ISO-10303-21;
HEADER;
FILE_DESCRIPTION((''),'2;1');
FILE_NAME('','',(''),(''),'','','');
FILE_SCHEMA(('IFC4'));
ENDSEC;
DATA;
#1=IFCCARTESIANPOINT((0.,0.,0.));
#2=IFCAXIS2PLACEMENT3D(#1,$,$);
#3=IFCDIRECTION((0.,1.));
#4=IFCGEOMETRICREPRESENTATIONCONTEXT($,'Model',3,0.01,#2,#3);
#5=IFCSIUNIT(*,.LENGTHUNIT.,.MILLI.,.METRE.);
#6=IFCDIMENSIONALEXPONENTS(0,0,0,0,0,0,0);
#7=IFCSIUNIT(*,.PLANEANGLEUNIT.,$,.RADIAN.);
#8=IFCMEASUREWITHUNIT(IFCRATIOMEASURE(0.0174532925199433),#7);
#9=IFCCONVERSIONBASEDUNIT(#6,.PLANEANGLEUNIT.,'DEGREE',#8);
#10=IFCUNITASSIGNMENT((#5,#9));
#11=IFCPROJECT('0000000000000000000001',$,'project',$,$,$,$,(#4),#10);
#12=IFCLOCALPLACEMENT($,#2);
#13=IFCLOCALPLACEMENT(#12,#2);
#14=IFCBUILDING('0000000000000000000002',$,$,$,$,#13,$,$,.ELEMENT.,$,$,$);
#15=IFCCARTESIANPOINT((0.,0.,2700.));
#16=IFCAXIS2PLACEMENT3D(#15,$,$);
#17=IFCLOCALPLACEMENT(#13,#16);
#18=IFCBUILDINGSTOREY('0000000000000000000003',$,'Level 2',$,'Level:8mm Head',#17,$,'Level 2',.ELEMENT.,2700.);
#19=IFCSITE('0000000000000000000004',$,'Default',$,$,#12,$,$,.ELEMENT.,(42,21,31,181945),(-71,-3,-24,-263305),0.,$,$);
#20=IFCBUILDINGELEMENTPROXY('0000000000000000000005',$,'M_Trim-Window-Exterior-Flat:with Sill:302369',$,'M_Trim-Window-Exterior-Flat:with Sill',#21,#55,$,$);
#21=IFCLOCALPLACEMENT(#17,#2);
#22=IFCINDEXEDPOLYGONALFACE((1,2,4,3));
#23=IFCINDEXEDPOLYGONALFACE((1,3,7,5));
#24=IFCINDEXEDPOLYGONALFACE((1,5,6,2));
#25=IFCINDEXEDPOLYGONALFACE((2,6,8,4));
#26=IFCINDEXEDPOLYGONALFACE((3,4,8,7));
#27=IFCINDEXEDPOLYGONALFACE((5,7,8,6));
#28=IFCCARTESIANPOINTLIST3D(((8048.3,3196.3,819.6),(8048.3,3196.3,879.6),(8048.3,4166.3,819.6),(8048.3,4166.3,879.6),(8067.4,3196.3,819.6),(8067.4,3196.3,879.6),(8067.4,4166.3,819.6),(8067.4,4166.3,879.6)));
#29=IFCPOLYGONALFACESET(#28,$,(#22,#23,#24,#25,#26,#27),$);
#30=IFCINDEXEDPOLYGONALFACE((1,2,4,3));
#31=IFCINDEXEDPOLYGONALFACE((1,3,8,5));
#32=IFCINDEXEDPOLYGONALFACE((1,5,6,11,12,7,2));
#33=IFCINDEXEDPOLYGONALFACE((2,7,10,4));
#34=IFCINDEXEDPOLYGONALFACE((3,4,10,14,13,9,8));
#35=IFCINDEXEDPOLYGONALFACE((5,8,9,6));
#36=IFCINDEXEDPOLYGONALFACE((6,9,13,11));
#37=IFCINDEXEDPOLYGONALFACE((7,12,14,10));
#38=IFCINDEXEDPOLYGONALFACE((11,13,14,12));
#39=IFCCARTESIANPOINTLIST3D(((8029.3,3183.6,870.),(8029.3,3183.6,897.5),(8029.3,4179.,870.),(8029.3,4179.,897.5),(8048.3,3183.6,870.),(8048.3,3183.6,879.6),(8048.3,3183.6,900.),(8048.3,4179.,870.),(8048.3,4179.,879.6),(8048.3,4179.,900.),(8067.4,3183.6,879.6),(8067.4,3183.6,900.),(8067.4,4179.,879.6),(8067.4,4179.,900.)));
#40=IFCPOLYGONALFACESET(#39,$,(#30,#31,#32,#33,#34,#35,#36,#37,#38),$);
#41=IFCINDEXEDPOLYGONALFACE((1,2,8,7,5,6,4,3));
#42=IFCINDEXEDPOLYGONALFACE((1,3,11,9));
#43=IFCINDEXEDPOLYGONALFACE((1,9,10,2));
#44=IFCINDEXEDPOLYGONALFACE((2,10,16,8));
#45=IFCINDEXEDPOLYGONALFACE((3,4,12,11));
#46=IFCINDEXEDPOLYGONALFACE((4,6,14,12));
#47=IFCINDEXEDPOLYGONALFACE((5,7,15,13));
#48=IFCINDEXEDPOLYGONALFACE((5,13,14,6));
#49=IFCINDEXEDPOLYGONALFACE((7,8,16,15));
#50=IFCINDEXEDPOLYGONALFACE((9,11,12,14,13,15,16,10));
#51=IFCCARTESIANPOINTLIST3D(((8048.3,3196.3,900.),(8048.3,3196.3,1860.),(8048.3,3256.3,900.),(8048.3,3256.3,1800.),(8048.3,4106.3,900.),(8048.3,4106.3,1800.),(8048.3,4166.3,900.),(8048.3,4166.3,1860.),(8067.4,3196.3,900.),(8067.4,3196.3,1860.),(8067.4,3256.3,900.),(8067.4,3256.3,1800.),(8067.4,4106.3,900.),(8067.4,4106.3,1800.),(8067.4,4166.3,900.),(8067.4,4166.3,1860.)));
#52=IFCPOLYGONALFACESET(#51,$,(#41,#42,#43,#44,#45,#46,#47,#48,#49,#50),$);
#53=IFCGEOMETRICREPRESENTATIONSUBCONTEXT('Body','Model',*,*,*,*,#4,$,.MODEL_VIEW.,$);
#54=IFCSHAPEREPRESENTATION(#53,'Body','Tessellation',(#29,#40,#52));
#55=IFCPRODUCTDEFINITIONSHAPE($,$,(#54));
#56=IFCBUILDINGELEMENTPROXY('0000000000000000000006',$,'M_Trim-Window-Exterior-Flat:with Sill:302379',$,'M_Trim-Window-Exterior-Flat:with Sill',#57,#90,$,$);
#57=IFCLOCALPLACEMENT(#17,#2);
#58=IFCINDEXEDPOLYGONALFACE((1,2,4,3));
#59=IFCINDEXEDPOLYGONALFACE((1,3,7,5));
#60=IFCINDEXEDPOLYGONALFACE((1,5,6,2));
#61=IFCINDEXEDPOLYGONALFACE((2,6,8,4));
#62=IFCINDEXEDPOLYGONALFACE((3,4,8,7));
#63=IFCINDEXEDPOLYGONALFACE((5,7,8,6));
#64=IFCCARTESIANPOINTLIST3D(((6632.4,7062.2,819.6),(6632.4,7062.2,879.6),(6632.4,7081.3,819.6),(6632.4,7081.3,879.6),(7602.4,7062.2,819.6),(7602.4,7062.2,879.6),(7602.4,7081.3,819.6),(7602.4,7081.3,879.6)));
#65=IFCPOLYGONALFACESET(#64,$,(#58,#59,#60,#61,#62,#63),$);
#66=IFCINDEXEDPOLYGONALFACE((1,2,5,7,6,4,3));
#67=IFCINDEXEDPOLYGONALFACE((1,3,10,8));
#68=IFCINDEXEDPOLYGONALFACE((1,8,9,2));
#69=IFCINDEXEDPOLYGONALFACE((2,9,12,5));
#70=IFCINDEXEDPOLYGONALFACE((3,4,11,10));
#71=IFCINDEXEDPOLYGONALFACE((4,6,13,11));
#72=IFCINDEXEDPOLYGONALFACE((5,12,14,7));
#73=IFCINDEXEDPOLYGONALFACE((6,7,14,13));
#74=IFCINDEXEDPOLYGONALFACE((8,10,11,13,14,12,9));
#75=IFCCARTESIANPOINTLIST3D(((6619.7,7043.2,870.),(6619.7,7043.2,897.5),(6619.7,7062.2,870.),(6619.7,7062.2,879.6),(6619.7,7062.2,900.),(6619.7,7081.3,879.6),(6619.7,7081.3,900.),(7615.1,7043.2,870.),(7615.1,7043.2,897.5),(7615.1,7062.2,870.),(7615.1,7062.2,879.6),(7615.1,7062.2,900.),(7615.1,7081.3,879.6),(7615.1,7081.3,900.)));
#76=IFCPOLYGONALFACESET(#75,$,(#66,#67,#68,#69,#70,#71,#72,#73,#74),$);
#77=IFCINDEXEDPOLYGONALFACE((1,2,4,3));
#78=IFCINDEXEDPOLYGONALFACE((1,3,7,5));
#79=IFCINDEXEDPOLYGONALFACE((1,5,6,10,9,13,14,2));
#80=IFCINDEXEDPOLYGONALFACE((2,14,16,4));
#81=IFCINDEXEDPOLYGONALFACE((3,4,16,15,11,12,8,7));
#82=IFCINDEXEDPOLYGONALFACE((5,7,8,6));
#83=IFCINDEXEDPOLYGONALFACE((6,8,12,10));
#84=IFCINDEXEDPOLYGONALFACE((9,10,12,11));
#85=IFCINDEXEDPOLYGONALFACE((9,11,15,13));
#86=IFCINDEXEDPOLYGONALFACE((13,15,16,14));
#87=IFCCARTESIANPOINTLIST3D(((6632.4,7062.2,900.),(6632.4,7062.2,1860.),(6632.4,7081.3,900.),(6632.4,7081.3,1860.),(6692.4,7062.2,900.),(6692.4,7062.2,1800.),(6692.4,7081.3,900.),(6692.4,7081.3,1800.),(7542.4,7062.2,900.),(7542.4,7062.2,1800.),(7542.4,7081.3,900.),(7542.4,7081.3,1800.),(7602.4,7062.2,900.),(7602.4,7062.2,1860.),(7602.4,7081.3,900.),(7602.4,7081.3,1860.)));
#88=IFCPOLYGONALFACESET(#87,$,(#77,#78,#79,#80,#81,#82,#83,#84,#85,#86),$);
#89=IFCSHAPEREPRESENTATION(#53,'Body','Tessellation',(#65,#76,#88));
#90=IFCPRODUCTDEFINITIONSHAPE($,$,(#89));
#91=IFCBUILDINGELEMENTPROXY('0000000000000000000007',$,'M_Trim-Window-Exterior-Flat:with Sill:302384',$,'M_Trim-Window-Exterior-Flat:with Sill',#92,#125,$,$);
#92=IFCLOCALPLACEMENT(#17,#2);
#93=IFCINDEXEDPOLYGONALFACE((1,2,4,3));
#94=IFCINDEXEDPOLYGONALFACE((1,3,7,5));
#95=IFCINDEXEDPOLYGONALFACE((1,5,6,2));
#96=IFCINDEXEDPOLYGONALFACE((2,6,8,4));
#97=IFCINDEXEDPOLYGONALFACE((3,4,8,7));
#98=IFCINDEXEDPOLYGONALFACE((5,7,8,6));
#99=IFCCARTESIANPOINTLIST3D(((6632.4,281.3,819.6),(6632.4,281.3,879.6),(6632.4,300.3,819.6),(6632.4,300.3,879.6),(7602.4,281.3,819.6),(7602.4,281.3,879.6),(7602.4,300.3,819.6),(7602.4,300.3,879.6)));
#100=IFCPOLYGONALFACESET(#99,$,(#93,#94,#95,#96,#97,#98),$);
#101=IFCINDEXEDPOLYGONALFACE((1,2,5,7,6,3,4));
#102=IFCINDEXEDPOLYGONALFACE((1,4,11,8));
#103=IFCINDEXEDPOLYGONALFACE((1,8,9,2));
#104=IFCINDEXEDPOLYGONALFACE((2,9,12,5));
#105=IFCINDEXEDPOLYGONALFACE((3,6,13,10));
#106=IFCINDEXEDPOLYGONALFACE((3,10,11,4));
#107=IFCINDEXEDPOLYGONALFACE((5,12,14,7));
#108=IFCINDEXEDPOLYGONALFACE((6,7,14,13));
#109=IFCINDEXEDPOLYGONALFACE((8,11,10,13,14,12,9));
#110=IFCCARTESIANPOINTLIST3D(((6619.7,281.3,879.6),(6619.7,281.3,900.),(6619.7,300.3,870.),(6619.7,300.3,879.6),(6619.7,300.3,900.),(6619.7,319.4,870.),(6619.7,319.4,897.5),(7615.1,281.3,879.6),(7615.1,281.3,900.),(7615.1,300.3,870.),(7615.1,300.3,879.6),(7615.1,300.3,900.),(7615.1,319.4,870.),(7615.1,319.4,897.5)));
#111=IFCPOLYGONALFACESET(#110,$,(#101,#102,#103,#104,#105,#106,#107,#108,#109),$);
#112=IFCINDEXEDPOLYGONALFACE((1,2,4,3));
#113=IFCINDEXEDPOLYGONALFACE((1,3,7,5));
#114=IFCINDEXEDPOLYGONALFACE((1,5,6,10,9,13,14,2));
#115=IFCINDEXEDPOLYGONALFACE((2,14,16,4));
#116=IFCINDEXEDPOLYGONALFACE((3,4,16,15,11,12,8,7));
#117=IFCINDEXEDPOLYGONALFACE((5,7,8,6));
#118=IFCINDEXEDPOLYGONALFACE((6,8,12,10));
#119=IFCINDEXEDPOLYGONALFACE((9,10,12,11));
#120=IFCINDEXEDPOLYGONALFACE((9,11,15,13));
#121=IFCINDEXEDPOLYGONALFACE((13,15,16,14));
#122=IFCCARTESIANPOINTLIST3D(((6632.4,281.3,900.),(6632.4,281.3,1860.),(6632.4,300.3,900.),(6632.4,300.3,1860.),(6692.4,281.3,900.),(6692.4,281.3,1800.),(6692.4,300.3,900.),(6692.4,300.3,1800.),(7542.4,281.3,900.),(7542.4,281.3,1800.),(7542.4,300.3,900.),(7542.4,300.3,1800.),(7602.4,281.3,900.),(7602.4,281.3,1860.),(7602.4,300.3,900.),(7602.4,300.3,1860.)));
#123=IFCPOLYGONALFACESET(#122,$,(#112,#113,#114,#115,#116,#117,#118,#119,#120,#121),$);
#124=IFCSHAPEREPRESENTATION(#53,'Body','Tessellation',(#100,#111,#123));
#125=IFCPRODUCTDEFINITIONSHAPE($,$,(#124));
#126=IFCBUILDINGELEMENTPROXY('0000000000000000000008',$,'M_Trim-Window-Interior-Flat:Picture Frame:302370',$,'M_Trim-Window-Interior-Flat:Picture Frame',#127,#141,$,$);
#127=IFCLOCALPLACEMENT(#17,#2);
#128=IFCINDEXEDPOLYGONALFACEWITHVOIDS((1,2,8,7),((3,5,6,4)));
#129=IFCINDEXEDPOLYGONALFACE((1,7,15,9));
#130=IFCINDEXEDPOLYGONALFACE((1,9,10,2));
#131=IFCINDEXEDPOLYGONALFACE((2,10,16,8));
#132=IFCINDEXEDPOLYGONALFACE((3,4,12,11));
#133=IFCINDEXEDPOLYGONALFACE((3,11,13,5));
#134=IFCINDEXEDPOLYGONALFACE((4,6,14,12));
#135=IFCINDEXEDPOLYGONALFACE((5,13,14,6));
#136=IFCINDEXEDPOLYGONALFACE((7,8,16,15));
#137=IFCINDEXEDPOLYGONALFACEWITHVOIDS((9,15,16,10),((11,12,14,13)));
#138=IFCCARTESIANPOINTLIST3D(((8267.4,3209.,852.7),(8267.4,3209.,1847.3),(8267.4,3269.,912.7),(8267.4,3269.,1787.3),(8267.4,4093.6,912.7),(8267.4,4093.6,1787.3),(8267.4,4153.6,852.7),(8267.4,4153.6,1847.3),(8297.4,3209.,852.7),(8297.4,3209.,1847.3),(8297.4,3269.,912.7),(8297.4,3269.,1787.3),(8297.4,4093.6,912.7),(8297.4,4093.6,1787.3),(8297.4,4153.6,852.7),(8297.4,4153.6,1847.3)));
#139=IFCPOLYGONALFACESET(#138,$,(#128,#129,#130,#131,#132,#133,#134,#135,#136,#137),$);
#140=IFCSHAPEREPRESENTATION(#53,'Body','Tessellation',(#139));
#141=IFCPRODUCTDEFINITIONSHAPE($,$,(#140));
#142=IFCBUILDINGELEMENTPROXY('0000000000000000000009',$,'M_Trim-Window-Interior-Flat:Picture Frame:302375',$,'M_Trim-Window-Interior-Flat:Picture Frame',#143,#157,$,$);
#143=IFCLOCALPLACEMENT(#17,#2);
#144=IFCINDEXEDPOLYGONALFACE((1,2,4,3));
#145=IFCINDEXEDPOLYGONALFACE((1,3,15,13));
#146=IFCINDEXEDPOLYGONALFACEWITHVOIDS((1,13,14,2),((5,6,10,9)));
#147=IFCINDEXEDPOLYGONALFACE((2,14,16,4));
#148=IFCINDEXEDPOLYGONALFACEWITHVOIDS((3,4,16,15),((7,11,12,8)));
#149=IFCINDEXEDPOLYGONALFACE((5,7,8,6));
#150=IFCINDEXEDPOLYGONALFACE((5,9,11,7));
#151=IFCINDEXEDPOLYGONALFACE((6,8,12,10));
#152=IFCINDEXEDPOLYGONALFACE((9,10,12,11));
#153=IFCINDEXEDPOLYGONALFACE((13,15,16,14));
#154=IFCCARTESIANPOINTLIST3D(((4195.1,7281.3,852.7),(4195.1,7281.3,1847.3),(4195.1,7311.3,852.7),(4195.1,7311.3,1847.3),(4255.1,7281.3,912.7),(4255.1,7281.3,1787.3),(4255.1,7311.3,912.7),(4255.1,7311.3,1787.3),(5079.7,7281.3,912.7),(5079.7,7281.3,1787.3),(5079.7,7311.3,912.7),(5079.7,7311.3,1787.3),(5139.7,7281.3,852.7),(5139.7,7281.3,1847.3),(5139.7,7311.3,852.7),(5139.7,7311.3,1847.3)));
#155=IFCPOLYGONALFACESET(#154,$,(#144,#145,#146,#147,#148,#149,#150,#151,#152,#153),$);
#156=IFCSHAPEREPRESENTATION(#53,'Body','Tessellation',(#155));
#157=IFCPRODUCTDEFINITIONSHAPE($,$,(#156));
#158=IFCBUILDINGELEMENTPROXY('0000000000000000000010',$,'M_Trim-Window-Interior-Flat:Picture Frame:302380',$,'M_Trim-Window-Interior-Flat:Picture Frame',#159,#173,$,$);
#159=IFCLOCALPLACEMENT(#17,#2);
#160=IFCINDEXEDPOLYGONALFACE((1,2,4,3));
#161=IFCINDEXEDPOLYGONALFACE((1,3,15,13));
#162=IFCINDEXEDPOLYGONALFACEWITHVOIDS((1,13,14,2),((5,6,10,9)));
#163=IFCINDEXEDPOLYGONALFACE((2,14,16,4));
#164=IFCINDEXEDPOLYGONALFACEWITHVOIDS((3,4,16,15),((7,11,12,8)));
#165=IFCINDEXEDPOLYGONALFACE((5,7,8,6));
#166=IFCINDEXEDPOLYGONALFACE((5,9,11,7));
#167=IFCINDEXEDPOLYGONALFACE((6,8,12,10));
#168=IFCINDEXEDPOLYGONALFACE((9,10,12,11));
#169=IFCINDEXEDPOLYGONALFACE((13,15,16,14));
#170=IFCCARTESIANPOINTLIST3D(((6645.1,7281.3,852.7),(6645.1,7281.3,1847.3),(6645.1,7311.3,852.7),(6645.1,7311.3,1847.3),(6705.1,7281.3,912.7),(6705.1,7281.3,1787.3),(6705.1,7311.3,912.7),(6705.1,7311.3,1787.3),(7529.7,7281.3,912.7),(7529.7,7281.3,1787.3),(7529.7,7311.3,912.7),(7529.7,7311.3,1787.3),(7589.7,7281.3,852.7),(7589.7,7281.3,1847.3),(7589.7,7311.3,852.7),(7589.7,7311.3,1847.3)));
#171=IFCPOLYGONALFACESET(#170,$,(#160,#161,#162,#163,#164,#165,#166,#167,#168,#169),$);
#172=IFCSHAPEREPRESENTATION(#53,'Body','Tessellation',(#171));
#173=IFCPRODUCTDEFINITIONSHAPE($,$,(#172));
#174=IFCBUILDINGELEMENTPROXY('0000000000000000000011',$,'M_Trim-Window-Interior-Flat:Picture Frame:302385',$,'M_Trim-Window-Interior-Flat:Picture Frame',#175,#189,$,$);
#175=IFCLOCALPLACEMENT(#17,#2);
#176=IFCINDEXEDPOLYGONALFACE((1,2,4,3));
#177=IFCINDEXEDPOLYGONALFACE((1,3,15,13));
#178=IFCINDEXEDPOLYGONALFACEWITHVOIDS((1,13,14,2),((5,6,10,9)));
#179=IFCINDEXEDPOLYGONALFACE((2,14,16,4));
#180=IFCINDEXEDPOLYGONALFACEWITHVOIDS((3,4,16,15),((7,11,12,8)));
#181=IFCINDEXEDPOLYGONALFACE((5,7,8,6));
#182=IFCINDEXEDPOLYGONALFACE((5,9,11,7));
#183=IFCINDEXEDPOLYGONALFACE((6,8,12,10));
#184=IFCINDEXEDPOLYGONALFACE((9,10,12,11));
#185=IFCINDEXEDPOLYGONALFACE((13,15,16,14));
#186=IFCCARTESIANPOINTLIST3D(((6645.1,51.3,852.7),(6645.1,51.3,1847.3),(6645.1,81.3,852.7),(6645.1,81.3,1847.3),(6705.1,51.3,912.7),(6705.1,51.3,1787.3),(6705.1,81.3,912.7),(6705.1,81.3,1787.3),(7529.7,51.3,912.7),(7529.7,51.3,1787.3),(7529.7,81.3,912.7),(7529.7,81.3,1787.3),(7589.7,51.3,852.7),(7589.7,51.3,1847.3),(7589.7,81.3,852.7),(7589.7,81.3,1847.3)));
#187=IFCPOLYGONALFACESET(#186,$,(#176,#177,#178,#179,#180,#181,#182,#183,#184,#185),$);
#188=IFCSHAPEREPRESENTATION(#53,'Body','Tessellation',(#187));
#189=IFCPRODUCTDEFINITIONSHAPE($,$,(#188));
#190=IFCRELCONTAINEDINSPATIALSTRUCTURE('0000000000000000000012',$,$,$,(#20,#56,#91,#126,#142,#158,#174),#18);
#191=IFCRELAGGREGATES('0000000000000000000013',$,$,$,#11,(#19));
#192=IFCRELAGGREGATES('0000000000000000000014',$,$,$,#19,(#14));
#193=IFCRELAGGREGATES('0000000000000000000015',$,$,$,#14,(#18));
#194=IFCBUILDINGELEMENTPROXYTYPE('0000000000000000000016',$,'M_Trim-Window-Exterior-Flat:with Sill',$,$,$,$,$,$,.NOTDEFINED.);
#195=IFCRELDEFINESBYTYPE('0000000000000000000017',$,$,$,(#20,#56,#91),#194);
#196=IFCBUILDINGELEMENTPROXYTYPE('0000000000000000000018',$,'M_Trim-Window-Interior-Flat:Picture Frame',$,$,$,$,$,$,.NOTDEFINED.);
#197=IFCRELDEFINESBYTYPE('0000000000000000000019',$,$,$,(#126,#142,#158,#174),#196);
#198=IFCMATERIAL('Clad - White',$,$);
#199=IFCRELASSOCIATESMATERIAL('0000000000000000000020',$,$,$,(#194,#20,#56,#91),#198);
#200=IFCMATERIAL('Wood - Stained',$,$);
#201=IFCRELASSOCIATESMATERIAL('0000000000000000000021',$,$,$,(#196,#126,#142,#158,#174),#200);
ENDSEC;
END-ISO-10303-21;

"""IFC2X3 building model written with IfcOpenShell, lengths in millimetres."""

from ifc_helpers import new_model, entity, si_unit, converted_unit, direction, frame, frame_2d, origin, place, context, subcontext, project, spatial, polyline, rectangle, outline, extrude, source, transform, mapped, material, type_object, type_shapes, element, save


model = new_model("IFC2X3")

# Units and contexts
model_context = context("Model", 3, precision=0.01, world=origin(), true_north=direction((0.0, 1.0)))
body_context = subcontext(model_context, "Body", "Model", "MODEL_VIEW")
ifc_project = project(units=[si_unit("LENGTHUNIT", "METRE", prefix="MILLI"), converted_unit("PLANEANGLEUNIT", "DEGREE", entity("IfcRatioMeasure", 0.0174532925199433), si_unit("PLANEANGLEUNIT", "RADIAN"), dimensions=[0, 0, 0, 0, 0, 0, 0])], contexts=[model_context])

# Site, building, storey
site_placement = place(None, origin())
site = spatial("IfcSite", under=ifc_project, at=site_placement, Name="Default", CompositionType="ELEMENT", RefLatitude=(42, 21, 31, 181945), RefLongitude=(-71, -3, -24, -263305), RefElevation=0.0)
building_placement = place(site_placement, origin())
building = spatial("IfcBuilding", under=site, at=building_placement, CompositionType="ELEMENT")
storey_placement = place(building_placement, frame((0.0, 0.0, 2700.0)))
storey = spatial("IfcBuildingStorey", under=building, at=storey_placement, Name="Level 2", ObjectType="Level:8mm Head", LongName="Level 2", CompositionType="ELEMENT", Elevation=2700.0)

# Building element proxies
ifc_material_1 = material(Name="Clad - White")
ifc_material_2 = material(Name="Wood - Stained")
building_element_proxy_type_1 = type_object("IfcBuildingElementProxyType", Name="M_Trim-Window-Exterior-Flat:with Sill", PredefinedType="NOTDEFINED", material=ifc_material_1)
shared_shape_1 = source(origin(), body_context, "Body", "SweptSolid", [
    extrude(rectangle(XDim=970.0, YDim=60.0, at=frame_2d((0.0, 0.0), x_axis=(1.0, 0.0))), frame((0.0, -950.4, 0.0), z_axis=(0.0, 0.0, 1.0), x_axis=(-1.0, 0.0, 0.0)), (0.0, 0.0, 1.0), 19.1),
    extrude(outline(polyline([(-19.0, -15.2), (0.0, -15.2), (0.0, -5.7), (19.0, -5.7), (19.0, 14.8), (0.0, 14.8), (-19.0, 12.3), (-19.0, -15.2)])), frame((-497.7, -914.8, 19.0), z_axis=(1.0, 0.0, 0.0), x_axis=(0.0, 0.0, -1.0)), (0.0, 0.0, 1.0), 995.4),
    extrude(outline(polyline([(-495.0, -485.0), (465.0, -485.0), (465.0, -425.0), (-435.0, -425.0), (-435.0, 425.0), (465.0, 425.0), (465.0, 485.0), (-495.0, 485.0), (-495.0, -485.0)])), frame((0.0, -435.0, 0.0), z_axis=(0.0, 0.0, 1.0), x_axis=(0.0, -1.0, 0.0)), (0.0, 0.0, 1.0), 19.1),
])
type_shapes(building_element_proxy_type_1, [shared_shape_1])
for number, where, z_axis, x_axis, name in (
    (1, (8067.4, 3681.3, 1800.0), (-1.0, 0.0, 0.0), (0.0, -1.0, 0.0), "M_Trim-Window-Exterior-Flat:with Sill:302369"),
    (2, (7117.4, 7081.3, 1800.0), (0.0, -1.0, 0.0), (1.0, 0.0, 0.0), "M_Trim-Window-Exterior-Flat:with Sill:302379"),
    (3, (7117.4, 281.3, 1800.0), (0.0, 1.0, 0.0), (-1.0, 0.0, 0.0), "M_Trim-Window-Exterior-Flat:with Sill:302384"),
):
    element("IfcBuildingElementProxy", number, at=place(storey_placement, frame(where, z_axis=z_axis, x_axis=x_axis)), inside=storey, type_object=building_element_proxy_type_1, material=ifc_material_1, Name=name, ObjectType="M_Trim-Window-Exterior-Flat:with Sill", context=body_context, shape_type="MappedRepresentation", body=[
        mapped(shared_shape_1, transform((0.0, 0.0, 0.0), scale=1.0)),
    ])
building_element_proxy_type_2 = type_object("IfcBuildingElementProxyType", Name="M_Trim-Window-Interior-Flat:Picture Frame", PredefinedType="NOTDEFINED", material=ifc_material_2)
shared_shape_2 = source(origin(), body_context, "Body", "SweptSolid", [
    extrude(outline(polyline([(-472.3, -497.3), (472.3, -497.3), (472.3, 497.3), (-472.3, 497.3), (-472.3, -497.3)]), holes=[polyline([(-412.3, -437.3), (-412.3, 437.3), (412.3, 437.3), (412.3, -437.3), (-412.3, -437.3)])]), frame((0.0, -450.0, 0.0), z_axis=(0.0, 0.0, 1.0), x_axis=(-1.0, 0.0, 0.0)), (0.0, 0.0, 1.0), 30.0),
])
type_shapes(building_element_proxy_type_2, [shared_shape_2])
for number, where, z_axis, x_axis, name in (
    (4, (8267.4, 3681.3, 1800.0), (1.0, 0.0, 0.0), (0.0, 1.0, 0.0), "M_Trim-Window-Interior-Flat:Picture Frame:302370"),
    (5, (4667.4, 7281.3, 1800.0), (0.0, 1.0, 0.0), (-1.0, 0.0, 0.0), "M_Trim-Window-Interior-Flat:Picture Frame:302375"),
    (6, (7117.4, 7281.3, 1800.0), (0.0, 1.0, 0.0), (-1.0, 0.0, 0.0), "M_Trim-Window-Interior-Flat:Picture Frame:302380"),
    (7, (7117.4, 81.3, 1800.0), (0.0, -1.0, 0.0), (1.0, 0.0, 0.0), "M_Trim-Window-Interior-Flat:Picture Frame:302385"),
):
    element("IfcBuildingElementProxy", number, at=place(storey_placement, frame(where, z_axis=z_axis, x_axis=x_axis)), inside=storey, type_object=building_element_proxy_type_2, material=ifc_material_2, Name=name, ObjectType="M_Trim-Window-Interior-Flat:Picture Frame", context=body_context, shape_type="MappedRepresentation", body=[
        mapped(shared_shape_2, transform((0.0, 0.0, 0.0), scale=1.0)),
    ])

save(model, "model.ifc")
